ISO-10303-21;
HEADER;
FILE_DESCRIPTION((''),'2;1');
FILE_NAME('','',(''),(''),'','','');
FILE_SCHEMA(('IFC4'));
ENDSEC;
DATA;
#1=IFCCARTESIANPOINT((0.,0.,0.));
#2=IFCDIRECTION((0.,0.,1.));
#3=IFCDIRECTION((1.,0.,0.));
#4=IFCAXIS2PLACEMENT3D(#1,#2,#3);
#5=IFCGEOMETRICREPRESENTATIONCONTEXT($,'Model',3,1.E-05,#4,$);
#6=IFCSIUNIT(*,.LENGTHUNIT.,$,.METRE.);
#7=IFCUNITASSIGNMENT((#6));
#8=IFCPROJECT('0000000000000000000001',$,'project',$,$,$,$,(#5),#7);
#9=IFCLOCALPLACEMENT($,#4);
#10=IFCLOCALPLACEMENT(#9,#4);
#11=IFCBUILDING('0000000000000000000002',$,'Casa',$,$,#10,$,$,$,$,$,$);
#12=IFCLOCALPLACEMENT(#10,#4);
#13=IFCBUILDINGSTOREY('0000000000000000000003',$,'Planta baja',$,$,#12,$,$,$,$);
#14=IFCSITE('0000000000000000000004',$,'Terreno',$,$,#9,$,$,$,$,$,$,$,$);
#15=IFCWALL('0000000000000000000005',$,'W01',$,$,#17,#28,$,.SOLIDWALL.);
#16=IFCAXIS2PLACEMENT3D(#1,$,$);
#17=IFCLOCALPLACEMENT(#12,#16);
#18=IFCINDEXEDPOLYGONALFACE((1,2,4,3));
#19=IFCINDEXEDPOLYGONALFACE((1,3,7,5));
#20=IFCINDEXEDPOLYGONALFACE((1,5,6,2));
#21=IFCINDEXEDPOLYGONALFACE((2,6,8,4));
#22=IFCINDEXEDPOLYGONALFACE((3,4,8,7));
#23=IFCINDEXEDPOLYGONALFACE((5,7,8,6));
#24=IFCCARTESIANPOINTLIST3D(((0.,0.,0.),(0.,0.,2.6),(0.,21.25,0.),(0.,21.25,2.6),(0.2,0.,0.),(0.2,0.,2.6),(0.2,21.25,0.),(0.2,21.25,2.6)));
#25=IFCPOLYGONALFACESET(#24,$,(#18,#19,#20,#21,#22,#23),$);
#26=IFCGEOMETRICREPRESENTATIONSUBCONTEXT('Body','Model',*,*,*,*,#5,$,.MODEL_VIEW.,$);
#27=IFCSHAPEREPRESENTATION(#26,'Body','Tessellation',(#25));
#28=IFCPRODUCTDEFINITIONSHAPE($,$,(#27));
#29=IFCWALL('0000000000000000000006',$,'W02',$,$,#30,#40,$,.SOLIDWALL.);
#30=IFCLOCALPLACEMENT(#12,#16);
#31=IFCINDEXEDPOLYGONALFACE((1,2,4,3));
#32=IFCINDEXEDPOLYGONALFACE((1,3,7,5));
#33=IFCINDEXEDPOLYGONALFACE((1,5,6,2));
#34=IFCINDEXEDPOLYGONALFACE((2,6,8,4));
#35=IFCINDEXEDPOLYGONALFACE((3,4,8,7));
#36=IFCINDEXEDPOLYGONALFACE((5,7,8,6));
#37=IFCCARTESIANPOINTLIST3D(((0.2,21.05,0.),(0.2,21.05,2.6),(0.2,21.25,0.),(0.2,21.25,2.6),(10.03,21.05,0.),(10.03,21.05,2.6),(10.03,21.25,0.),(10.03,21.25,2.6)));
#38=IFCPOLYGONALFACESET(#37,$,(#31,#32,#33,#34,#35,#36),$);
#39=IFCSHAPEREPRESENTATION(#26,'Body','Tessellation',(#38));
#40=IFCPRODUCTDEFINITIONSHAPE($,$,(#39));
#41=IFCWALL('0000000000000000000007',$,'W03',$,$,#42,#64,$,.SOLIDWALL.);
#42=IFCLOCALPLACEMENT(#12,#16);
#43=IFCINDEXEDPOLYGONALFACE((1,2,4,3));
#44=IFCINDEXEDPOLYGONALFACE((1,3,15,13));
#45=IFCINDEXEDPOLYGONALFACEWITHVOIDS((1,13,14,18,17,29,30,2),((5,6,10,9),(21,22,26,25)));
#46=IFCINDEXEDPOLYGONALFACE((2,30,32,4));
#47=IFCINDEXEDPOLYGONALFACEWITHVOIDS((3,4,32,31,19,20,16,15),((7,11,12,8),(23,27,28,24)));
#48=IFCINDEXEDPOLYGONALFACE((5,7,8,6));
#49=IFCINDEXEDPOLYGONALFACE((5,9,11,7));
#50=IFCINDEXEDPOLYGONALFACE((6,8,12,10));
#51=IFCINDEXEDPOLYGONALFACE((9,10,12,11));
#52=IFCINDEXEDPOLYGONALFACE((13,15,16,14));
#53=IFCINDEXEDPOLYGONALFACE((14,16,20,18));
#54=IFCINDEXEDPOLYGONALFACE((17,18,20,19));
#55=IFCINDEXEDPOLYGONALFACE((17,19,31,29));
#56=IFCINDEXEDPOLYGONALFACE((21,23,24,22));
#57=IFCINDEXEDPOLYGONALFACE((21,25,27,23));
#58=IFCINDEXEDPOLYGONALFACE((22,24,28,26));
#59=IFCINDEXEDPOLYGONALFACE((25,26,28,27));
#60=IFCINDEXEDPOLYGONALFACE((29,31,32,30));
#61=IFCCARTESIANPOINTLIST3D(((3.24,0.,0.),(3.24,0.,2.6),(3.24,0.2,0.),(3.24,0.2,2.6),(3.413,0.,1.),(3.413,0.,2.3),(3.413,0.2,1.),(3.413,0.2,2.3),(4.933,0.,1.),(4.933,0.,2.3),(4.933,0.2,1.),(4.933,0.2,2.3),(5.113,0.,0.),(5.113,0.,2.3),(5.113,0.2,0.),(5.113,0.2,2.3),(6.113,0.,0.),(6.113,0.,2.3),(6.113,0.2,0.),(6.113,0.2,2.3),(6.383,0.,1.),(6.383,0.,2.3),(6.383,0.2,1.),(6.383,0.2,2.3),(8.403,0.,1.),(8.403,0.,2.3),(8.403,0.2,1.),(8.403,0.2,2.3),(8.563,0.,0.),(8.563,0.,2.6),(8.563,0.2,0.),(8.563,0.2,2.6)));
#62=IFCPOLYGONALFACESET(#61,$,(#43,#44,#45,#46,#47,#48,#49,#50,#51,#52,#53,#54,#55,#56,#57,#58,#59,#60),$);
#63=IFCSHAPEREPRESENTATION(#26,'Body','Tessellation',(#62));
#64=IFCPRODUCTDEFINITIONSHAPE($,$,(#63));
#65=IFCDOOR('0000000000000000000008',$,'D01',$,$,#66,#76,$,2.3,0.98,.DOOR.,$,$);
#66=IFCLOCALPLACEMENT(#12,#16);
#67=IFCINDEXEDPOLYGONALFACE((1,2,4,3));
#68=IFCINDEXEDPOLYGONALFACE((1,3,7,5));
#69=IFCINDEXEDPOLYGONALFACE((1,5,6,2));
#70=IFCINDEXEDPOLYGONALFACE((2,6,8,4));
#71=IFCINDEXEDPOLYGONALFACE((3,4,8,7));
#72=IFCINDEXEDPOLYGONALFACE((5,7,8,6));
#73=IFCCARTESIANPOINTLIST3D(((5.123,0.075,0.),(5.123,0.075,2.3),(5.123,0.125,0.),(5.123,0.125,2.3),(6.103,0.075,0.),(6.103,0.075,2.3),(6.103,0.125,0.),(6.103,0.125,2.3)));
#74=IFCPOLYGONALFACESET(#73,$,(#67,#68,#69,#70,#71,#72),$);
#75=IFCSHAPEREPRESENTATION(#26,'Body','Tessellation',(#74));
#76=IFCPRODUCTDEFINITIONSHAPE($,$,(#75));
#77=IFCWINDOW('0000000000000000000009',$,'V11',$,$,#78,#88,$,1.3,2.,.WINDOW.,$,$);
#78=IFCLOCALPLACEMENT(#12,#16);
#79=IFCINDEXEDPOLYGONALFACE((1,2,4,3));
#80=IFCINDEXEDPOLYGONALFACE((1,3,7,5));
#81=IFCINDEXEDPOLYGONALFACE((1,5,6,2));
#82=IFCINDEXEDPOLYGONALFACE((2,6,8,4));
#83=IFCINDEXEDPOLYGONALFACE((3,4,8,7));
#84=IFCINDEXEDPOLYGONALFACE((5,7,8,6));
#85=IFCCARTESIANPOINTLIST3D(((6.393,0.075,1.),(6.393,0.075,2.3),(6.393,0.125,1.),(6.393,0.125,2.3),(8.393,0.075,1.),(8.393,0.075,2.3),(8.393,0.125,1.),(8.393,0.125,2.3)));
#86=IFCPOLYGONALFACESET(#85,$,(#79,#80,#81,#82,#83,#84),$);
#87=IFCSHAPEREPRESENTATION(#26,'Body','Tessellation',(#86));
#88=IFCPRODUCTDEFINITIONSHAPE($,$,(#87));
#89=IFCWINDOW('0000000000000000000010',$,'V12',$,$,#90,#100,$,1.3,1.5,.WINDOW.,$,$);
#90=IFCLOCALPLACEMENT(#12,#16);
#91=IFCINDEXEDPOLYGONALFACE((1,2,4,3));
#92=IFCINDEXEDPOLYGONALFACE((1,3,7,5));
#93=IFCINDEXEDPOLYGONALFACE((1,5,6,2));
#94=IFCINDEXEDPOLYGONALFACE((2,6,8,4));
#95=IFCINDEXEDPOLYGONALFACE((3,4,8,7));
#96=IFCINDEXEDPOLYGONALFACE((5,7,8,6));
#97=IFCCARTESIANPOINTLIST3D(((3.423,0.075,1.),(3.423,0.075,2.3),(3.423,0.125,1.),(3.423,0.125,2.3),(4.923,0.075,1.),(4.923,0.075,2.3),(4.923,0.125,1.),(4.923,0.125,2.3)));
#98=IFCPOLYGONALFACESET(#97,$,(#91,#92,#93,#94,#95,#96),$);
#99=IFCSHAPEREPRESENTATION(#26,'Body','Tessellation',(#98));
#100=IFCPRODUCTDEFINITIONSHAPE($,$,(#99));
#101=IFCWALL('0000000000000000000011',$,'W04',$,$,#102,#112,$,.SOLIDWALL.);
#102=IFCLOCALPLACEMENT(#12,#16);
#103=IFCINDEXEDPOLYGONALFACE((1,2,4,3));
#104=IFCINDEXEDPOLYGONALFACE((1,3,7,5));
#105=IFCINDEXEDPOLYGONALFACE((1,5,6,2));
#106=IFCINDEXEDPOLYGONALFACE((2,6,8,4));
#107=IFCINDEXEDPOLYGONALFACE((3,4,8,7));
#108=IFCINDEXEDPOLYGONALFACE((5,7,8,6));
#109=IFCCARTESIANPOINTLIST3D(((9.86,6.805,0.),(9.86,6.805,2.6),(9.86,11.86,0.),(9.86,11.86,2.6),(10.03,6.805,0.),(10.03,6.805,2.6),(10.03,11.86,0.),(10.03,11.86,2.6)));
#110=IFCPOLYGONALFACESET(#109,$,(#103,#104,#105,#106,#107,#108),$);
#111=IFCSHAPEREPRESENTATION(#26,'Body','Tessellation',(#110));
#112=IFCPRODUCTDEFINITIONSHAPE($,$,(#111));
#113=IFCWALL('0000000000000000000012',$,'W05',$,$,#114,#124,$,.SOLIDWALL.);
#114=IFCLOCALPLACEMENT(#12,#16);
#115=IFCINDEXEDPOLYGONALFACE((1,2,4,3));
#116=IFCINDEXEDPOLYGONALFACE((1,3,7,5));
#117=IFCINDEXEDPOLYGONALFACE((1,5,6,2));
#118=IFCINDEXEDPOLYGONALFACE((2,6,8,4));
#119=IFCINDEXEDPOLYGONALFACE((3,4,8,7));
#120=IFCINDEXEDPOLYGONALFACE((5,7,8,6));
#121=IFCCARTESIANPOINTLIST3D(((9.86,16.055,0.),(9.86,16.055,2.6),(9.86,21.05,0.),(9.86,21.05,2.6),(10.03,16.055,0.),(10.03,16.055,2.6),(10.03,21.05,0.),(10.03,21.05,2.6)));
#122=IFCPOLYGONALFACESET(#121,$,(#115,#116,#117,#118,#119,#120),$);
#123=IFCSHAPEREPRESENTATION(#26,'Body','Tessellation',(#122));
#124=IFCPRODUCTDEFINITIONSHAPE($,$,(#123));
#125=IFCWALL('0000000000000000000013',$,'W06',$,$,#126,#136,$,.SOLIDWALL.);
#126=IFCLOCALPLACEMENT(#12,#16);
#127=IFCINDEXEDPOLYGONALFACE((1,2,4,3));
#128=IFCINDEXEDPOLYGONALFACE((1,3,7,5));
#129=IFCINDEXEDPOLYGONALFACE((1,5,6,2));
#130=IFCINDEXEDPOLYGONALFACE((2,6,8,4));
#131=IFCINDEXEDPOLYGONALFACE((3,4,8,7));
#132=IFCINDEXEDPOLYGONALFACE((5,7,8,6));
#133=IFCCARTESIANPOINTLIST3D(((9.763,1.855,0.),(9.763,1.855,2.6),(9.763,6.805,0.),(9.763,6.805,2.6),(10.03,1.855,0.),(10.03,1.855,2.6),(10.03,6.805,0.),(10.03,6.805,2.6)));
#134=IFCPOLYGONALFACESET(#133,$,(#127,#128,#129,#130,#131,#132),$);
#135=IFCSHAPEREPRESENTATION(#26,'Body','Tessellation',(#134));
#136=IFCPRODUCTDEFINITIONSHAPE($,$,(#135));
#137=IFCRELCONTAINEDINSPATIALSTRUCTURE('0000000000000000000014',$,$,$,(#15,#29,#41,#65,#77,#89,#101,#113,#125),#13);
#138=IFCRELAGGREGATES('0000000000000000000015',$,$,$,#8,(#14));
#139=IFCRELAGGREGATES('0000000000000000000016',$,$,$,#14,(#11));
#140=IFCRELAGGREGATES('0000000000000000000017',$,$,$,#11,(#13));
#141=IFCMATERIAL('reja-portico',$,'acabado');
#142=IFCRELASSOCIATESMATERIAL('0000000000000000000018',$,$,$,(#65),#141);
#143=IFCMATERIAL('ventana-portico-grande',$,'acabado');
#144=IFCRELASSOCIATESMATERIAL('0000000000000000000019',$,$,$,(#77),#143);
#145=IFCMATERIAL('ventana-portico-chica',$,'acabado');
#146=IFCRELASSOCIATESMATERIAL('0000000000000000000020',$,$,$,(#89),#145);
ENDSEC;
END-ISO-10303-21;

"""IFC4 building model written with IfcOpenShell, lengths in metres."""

from ifc_helpers import new_model, si_unit, frame, origin_with_axes, place, context, subcontext, project, spatial, line, indexed_curve, outline, extrude, material, element, fill, save


model = new_model("IFC4")

# Units and contexts
model_context = context("Model", 3, precision=1e-05, world=origin_with_axes())
body_context = subcontext(model_context, "Body", "Model", "MODEL_VIEW")
ifc_project = project(units=[si_unit("LENGTHUNIT", "METRE")], contexts=[model_context])

# Site, building, storey
site_placement = place(None, origin_with_axes())
site = spatial("IfcSite", under=ifc_project, at=site_placement, Name="Terreno")
building_placement = place(site_placement, origin_with_axes())
building = spatial("IfcBuilding", under=site, at=building_placement, Name="Casa")
storey_placement = place(building_placement, origin_with_axes())
storey = spatial("IfcBuildingStorey", under=building, at=storey_placement, Name="Planta baja")

# Walls
wall_1_placement = place(storey_placement, origin_with_axes())
element("IfcWall", 1, at=wall_1_placement, inside=storey, Name="W01", PredefinedType="SOLIDWALL", context=body_context, shape_type="SweptSolid", body=[
    extrude(outline(indexed_curve([(0.2, 0.0), (0.0, 0.0), (0.0, 21.25), (0.2, 21.25)], segments=[line(1, 2, 3, 4, 1)])), origin_with_axes(), (0.0, 0.0, 1.0), 2.6),
])
wall_2_placement = place(storey_placement, origin_with_axes())
element("IfcWall", 2, at=wall_2_placement, inside=storey, Name="W02", PredefinedType="SOLIDWALL", context=body_context, shape_type="SweptSolid", body=[
    extrude(outline(indexed_curve([(0.2, 21.05), (0.2, 21.25), (10.03, 21.25), (10.03, 21.05)], segments=[line(1, 2, 3, 4, 1)])), origin_with_axes(), (0.0, 0.0, 1.0), 2.6),
])

# Wall, openings, door, windows
wall_3_placement = place(storey_placement, origin_with_axes())
wall_3 = element("IfcWall", 3, at=wall_3_placement, inside=storey, Name="W03", PredefinedType="SOLIDWALL", context=body_context, shape_type="SweptSolid", body=[
    extrude(outline(indexed_curve([(3.24, 0.2), (8.563, 0.2), (8.563, 0.0), (3.24, 0.0)], segments=[line(1, 2, 3, 4, 1)])), origin_with_axes(), (0.0, 0.0, 1.0), 2.6),
])
opening_1_placement = place(wall_3_placement, origin_with_axes())
opening_1 = element("IfcOpeningElement", 4, at=opening_1_placement, cuts=wall_3, PredefinedType="OPENING", context=body_context, shape_type="SweptSolid", body=[
    extrude(outline(indexed_curve([(5.113, -0.01), (6.113, -0.01), (6.113, 0.21), (5.113, 0.21)], segments=[line(1, 2, 3, 4, 1)])), origin_with_axes(), (0.0, 0.0, 1.0), 2.3),
])
opening_2_placement = place(wall_3_placement, origin_with_axes())
opening_2 = element("IfcOpeningElement", 5, at=opening_2_placement, cuts=wall_3, PredefinedType="OPENING", context=body_context, shape_type="SweptSolid", body=[
    extrude(outline(indexed_curve([(6.383, -0.01), (8.403, -0.01), (8.403, 0.21), (6.383, 0.21)], segments=[line(1, 2, 3, 4, 1)])), frame((0.0, 0.0, 1.0), z_axis=(0.0, 0.0, 1.0), x_axis=(1.0, 0.0, 0.0)), (0.0, 0.0, 1.0), 1.3),
])
opening_3_placement = place(wall_3_placement, origin_with_axes())
opening_3 = element("IfcOpeningElement", 6, at=opening_3_placement, cuts=wall_3, PredefinedType="OPENING", context=body_context, shape_type="SweptSolid", body=[
    extrude(outline(indexed_curve([(3.413, -0.01), (4.933, -0.01), (4.933, 0.21), (3.413, 0.21)], segments=[line(1, 2, 3, 4, 1)])), frame((0.0, 0.0, 1.0), z_axis=(0.0, 0.0, 1.0), x_axis=(1.0, 0.0, 0.0)), (0.0, 0.0, 1.0), 1.3),
])
ifc_material_1 = material(Name="reja-portico", Category="acabado")
door_1_placement = place(opening_1_placement, origin_with_axes())
door_1 = element("IfcDoor", 7, at=door_1_placement, inside=storey, material=ifc_material_1, Name="D01", OverallHeight=2.3, OverallWidth=0.98, PredefinedType="DOOR", context=body_context, shape_type="SweptSolid", body=[
    extrude(outline(indexed_curve([(5.123, 0.075), (6.103, 0.075), (6.103, 0.125), (5.123, 0.125)], segments=[line(1, 2, 3, 4, 1)])), origin_with_axes(), (0.0, 0.0, 1.0), 2.3),
])
fill(opening_1, door_1)
ifc_material_2 = material(Name="ventana-portico-grande", Category="acabado")
window_1_placement = place(opening_2_placement, origin_with_axes())
window_1 = element("IfcWindow", 8, at=window_1_placement, inside=storey, material=ifc_material_2, Name="V11", OverallHeight=1.3, OverallWidth=2.0, PredefinedType="WINDOW", context=body_context, shape_type="SweptSolid", body=[
    extrude(outline(indexed_curve([(6.393, 0.075), (8.393, 0.075), (8.393, 0.125), (6.393, 0.125)], segments=[line(1, 2, 3, 4, 1)])), frame((0.0, 0.0, 1.0), z_axis=(0.0, 0.0, 1.0), x_axis=(1.0, 0.0, 0.0)), (0.0, 0.0, 1.0), 1.3),
])
fill(opening_2, window_1)
ifc_material_3 = material(Name="ventana-portico-chica", Category="acabado")
window_2_placement = place(opening_3_placement, origin_with_axes())
window_2 = element("IfcWindow", 9, at=window_2_placement, inside=storey, material=ifc_material_3, Name="V12", OverallHeight=1.3, OverallWidth=1.5, PredefinedType="WINDOW", context=body_context, shape_type="SweptSolid", body=[
    extrude(outline(indexed_curve([(3.423, 0.075), (4.923, 0.075), (4.923, 0.125), (3.423, 0.125)], segments=[line(1, 2, 3, 4, 1)])), frame((0.0, 0.0, 1.0), z_axis=(0.0, 0.0, 1.0), x_axis=(1.0, 0.0, 0.0)), (0.0, 0.0, 1.0), 1.3),
])
fill(opening_3, window_2)

# Walls
wall_4_placement = place(storey_placement, origin_with_axes())
element("IfcWall", 10, at=wall_4_placement, inside=storey, Name="W04", PredefinedType="SOLIDWALL", context=body_context, shape_type="SweptSolid", body=[
    extrude(outline(indexed_curve([(9.86, 11.86), (10.03, 11.86), (10.03, 6.805), (9.86, 6.805)], segments=[line(1, 2, 3, 4, 1)])), origin_with_axes(), (0.0, 0.0, 1.0), 2.6),
])
wall_5_placement = place(storey_placement, origin_with_axes())
element("IfcWall", 11, at=wall_5_placement, inside=storey, Name="W05", PredefinedType="SOLIDWALL", context=body_context, shape_type="SweptSolid", body=[
    extrude(outline(indexed_curve([(9.86, 21.05), (10.03, 21.05), (10.03, 16.055), (9.86, 16.055)], segments=[line(1, 2, 3, 4, 1)])), origin_with_axes(), (0.0, 0.0, 1.0), 2.6),
])
wall_6_placement = place(storey_placement, origin_with_axes())
element("IfcWall", 12, at=wall_6_placement, inside=storey, Name="W06", PredefinedType="SOLIDWALL", context=body_context, shape_type="SweptSolid", body=[
    extrude(outline(indexed_curve([(9.763, 6.805), (10.03, 6.805), (10.03, 1.855), (9.763, 1.855)], segments=[line(1, 2, 3, 4, 1)])), origin_with_axes(), (0.0, 0.0, 1.0), 2.6),
])

save(model, "model.ifc")
